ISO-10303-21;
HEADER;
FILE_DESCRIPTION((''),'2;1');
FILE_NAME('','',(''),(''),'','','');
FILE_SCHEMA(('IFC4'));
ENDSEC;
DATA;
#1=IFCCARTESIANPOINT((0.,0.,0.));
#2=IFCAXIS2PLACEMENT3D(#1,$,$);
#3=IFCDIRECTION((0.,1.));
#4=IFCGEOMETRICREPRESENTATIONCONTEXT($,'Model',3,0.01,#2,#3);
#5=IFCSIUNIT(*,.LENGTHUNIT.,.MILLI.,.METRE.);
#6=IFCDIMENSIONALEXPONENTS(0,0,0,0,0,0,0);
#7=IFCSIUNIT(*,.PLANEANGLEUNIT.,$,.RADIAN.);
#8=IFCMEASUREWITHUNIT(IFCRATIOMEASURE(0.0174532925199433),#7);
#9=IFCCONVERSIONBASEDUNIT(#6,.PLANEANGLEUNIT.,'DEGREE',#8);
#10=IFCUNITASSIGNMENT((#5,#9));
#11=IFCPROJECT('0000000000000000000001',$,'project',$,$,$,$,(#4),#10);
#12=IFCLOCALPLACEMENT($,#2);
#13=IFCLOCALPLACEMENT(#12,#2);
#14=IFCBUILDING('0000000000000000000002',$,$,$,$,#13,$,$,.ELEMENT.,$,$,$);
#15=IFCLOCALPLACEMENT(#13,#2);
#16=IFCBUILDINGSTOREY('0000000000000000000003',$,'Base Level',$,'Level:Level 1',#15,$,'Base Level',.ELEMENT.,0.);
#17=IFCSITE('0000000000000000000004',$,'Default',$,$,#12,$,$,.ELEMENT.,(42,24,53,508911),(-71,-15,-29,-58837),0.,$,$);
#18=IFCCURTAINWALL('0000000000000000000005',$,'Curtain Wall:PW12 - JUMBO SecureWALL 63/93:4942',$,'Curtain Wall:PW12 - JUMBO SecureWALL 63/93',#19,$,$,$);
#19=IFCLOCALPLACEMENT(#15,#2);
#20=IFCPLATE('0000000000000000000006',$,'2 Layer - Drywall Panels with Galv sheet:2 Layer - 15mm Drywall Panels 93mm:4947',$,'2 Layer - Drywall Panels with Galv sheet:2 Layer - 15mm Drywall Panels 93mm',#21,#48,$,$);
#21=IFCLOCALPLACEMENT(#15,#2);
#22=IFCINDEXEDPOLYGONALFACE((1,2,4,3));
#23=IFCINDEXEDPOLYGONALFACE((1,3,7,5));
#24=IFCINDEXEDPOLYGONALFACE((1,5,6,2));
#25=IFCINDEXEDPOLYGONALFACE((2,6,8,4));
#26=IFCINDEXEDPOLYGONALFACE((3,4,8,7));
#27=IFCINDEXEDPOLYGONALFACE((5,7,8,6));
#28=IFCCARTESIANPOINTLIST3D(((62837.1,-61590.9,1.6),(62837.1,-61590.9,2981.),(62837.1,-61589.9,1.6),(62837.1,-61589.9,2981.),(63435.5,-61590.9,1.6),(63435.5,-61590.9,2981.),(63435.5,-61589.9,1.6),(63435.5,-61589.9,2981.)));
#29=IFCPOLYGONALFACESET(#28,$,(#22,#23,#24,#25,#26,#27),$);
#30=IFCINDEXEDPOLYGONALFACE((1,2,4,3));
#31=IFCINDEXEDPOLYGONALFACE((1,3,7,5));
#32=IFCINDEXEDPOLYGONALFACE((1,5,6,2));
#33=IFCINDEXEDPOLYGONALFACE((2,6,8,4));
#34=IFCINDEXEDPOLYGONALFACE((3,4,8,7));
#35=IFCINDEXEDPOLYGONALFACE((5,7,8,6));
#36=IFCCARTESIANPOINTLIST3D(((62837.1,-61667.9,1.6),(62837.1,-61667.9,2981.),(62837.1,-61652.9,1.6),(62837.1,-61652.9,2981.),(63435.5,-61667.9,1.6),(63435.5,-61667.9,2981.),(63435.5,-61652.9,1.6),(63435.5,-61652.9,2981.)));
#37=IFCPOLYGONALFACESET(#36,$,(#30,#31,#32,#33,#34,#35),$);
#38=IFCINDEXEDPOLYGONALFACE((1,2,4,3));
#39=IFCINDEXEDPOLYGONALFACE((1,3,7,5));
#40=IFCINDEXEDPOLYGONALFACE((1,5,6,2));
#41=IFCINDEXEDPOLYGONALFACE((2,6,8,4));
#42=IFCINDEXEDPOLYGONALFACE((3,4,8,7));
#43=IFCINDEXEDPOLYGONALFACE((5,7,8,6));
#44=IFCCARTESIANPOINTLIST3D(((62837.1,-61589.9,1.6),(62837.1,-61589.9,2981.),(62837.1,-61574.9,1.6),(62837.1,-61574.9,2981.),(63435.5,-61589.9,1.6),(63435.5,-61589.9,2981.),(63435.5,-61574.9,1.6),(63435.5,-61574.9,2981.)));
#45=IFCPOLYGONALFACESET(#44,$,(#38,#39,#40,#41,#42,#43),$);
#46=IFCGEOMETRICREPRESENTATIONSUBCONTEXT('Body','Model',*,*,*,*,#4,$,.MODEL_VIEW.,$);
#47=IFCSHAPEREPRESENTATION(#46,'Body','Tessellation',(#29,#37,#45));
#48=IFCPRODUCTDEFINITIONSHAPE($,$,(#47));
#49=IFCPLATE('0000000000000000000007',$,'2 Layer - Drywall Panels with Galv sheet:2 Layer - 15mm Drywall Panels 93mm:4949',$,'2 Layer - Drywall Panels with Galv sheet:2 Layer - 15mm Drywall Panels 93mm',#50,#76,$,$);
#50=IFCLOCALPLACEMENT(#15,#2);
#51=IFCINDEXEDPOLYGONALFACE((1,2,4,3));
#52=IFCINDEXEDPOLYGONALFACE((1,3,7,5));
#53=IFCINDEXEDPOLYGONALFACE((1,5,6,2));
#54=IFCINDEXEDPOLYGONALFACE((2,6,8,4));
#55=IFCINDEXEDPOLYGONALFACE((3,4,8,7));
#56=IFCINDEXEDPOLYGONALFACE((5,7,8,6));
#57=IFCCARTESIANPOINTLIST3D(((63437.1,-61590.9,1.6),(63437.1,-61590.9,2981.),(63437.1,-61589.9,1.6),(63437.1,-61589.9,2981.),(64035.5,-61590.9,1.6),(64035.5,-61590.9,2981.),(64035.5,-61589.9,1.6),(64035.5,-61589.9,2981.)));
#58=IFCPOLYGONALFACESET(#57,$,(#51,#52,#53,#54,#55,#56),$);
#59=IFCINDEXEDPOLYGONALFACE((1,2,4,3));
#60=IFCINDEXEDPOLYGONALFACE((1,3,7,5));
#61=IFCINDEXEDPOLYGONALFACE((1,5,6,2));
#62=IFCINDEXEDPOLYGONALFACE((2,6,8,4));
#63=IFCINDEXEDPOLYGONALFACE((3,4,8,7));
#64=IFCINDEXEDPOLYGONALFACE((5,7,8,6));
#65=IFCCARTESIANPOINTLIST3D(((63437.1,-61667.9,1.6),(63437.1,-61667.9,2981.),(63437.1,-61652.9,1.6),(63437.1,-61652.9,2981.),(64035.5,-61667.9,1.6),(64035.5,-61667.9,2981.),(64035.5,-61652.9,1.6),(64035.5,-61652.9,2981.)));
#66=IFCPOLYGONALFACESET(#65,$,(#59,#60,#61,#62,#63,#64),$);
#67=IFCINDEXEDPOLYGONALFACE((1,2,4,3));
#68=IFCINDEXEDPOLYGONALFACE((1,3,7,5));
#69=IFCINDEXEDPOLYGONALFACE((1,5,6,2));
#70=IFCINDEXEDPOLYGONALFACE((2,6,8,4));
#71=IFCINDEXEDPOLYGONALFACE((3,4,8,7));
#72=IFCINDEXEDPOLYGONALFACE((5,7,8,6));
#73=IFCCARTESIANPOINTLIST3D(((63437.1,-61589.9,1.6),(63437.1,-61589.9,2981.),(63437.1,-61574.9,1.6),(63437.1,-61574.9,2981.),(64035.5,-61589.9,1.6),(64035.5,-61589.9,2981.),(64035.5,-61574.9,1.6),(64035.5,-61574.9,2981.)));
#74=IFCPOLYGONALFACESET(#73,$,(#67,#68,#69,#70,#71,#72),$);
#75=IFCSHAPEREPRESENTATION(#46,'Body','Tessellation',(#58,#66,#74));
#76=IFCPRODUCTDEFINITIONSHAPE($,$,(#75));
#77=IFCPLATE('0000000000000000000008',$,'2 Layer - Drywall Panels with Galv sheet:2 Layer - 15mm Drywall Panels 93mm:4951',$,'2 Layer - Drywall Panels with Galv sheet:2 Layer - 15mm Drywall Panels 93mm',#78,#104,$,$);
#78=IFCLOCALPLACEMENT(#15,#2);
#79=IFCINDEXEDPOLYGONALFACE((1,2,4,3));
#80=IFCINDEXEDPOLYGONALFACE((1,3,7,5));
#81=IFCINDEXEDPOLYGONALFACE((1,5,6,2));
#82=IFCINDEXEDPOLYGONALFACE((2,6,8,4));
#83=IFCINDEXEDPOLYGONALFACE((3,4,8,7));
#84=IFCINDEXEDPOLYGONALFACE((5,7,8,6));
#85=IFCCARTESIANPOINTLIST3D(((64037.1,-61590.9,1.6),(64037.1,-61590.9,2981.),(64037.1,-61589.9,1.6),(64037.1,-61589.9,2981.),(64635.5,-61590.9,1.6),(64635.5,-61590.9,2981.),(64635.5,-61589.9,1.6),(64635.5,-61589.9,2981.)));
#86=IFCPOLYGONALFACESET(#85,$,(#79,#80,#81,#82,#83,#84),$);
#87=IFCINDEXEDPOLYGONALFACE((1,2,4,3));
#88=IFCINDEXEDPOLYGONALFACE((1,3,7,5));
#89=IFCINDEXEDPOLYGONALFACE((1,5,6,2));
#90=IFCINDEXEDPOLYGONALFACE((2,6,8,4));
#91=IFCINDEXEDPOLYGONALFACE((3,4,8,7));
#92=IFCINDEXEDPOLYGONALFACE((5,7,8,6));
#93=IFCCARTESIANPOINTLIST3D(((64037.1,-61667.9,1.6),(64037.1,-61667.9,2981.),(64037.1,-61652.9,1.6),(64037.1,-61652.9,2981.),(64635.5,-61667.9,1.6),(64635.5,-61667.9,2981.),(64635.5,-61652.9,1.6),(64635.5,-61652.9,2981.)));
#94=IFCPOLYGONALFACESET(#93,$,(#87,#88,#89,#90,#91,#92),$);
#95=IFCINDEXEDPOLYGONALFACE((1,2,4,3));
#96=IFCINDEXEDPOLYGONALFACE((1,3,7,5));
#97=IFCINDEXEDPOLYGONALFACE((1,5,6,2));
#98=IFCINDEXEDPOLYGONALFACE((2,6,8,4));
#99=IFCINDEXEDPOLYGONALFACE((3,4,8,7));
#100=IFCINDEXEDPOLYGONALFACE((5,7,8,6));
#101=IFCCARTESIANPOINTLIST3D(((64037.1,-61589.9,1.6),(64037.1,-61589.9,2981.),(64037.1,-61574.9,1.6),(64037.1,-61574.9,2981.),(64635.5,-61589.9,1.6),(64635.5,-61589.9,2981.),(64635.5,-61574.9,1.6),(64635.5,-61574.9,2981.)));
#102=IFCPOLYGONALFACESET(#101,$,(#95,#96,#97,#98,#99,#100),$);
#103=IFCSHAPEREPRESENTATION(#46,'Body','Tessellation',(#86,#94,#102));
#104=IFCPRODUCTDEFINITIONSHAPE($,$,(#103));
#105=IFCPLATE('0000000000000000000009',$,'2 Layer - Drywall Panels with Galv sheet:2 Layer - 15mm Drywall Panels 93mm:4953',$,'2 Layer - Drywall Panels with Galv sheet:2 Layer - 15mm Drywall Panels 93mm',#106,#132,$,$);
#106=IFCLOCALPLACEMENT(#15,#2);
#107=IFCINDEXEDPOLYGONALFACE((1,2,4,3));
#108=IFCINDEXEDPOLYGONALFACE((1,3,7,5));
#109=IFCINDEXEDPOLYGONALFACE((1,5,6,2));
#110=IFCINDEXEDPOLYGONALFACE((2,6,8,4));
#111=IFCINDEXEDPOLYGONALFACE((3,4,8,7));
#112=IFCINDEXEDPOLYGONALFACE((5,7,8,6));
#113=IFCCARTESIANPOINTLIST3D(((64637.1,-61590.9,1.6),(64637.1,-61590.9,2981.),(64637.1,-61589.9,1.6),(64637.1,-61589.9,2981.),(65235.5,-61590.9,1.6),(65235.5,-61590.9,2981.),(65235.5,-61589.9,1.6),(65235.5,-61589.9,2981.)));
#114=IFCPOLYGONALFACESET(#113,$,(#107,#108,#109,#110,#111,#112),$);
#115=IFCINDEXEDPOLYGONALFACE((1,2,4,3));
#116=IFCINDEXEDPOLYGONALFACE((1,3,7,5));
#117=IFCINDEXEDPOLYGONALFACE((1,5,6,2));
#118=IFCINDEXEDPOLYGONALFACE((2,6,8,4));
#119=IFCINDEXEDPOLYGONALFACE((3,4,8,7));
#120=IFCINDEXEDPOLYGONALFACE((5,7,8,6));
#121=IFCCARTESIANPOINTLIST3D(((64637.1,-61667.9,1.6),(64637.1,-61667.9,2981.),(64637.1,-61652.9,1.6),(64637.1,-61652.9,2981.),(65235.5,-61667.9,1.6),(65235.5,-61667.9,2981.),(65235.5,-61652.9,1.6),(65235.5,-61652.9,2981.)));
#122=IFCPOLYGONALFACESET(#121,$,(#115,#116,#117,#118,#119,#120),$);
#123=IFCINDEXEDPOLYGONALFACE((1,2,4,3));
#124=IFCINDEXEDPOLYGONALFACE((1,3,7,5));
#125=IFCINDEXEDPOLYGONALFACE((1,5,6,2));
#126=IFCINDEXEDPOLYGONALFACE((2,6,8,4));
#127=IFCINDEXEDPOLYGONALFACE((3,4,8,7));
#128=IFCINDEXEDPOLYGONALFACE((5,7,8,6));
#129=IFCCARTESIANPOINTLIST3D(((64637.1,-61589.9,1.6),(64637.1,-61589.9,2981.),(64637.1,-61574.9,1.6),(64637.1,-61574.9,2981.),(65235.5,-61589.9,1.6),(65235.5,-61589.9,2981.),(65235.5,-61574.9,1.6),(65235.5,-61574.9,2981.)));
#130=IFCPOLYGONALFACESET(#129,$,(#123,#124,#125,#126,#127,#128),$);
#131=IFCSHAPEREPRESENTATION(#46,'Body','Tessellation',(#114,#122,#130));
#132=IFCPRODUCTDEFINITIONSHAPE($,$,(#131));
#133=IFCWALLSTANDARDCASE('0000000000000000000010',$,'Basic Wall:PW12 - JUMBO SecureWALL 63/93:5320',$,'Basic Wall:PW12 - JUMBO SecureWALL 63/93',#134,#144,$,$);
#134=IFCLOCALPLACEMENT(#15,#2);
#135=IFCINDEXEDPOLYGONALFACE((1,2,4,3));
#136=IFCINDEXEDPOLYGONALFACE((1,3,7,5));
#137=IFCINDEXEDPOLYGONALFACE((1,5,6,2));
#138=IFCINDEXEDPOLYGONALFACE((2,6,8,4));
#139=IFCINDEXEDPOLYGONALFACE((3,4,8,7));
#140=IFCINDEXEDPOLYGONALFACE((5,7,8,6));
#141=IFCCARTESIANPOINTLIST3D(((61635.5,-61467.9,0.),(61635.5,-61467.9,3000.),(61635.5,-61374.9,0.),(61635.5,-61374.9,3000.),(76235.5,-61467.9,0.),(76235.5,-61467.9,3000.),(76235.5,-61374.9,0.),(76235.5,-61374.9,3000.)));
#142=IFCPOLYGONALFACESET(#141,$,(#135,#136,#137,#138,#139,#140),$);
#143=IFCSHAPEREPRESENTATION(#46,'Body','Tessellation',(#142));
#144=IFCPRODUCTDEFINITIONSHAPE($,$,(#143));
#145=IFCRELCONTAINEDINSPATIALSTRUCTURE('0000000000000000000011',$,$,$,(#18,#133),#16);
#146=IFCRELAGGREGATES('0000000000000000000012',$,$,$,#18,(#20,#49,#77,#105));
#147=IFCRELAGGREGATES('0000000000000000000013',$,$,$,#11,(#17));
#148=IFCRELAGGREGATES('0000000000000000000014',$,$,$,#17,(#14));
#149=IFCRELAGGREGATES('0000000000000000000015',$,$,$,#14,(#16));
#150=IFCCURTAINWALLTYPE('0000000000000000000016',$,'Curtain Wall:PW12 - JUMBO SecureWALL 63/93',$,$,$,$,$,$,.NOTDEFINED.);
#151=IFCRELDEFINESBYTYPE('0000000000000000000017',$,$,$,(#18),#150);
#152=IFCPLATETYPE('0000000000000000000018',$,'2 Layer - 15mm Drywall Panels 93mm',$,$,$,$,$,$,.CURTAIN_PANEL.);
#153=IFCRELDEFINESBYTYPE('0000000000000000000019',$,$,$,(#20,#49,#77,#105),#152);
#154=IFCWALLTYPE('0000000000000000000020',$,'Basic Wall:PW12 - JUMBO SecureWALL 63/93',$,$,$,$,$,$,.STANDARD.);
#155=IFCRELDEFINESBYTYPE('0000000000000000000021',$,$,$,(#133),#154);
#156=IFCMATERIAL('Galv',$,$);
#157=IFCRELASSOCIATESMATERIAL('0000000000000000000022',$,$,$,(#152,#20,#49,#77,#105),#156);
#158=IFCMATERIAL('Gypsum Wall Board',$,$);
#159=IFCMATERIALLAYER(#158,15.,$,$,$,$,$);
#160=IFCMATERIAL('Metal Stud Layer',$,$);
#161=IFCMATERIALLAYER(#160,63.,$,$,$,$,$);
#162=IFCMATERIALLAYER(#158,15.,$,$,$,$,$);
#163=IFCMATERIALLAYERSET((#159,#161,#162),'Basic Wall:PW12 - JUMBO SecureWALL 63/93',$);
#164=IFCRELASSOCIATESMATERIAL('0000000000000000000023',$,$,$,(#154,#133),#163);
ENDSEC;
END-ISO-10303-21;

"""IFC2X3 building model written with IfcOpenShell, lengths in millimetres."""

from ifc_helpers import new_model, entity, si_unit, converted_unit, direction, frame, frame_2d, origin, origin_2d_with_axis, place, context, subcontext, project, spatial, rectangle, extrude, source, transform, mapped, material, layer, layer_set, layer_usage, type_object, type_shapes, element, aggregate, save


model = new_model("IFC2X3")

# Units and contexts
model_context = context("Model", 3, precision=0.01, world=origin(), true_north=direction((0.0, 1.0)))
body_context = subcontext(model_context, "Body", "Model", "MODEL_VIEW")
ifc_project = project(units=[si_unit("LENGTHUNIT", "METRE", prefix="MILLI"), converted_unit("PLANEANGLEUNIT", "DEGREE", entity("IfcRatioMeasure", 0.0174532925199433), si_unit("PLANEANGLEUNIT", "RADIAN"), dimensions=[0, 0, 0, 0, 0, 0, 0])], contexts=[model_context])

# Site, building, storey
site_placement = place(None, origin())
site = spatial("IfcSite", under=ifc_project, at=site_placement, Name="Default", CompositionType="ELEMENT", RefLatitude=(42, 24, 53, 508911), RefLongitude=(-71, -15, -29, -58837), RefElevation=0.0)
building_placement = place(site_placement, origin())
building = spatial("IfcBuilding", under=site, at=building_placement, CompositionType="ELEMENT")
storey_placement = place(building_placement, origin())
storey = spatial("IfcBuildingStorey", under=building, at=storey_placement, Name="Base Level", ObjectType="Level:Level 1", LongName="Base Level", CompositionType="ELEMENT", Elevation=0.0)

# Curtain wall, plates
curtain_wall_type = type_object("IfcCurtainWallType", Name="Curtain Wall:PW12 - JUMBO SecureWALL 63/93", PredefinedType="NOTDEFINED")
curtain_wall_placement = place(building_placement, origin())
curtain_wall = element("IfcCurtainWall", 1, at=curtain_wall_placement, inside=storey, type_object=curtain_wall_type, Name="Curtain Wall:PW12 - JUMBO SecureWALL 63/93:4942", ObjectType="Curtain Wall:PW12 - JUMBO SecureWALL 63/93")
ifc_material_1 = material(Name="Galv")
plate_type = type_object("IfcPlateType", Name="2 Layer - 15mm Drywall Panels 93mm", PredefinedType="CURTAIN_PANEL", material=ifc_material_1)
shared_shape_1 = source(origin(), body_context, "Body", "SweptSolid", [
    extrude(rectangle(XDim=598.4, YDim=1.0, at=origin_2d_with_axis()), frame((0.0, 31.0, 0.0), z_axis=(0.0, 0.0, 1.0), x_axis=(-1.0, 0.0, 0.0)), (0.0, 0.0, 1.0), 2979.4),
    extrude(rectangle(XDim=598.4, YDim=15.0, at=frame_2d((0.0, 0.0), x_axis=(1.0, 0.0))), frame((0.0, -39.0, 0.0), z_axis=(0.0, 0.0, 1.0), x_axis=(-1.0, 0.0, 0.0)), (0.0, 0.0, 1.0), 2979.4),
    extrude(rectangle(XDim=15.0, YDim=598.4, at=frame_2d((0.0, 0.0), x_axis=(1.0, 0.0))), frame((0.0, 39.0, 0.0), z_axis=(0.0, 0.0, 1.0), x_axis=(0.0, 1.0, 0.0)), (0.0, 0.0, 1.0), 2979.4),
])
type_shapes(plate_type, [shared_shape_1])
plate_1_placement = place(curtain_wall_placement, frame((63136.3, -61621.4, 1.6)))
plate_1 = element("IfcPlate", 2, at=plate_1_placement, type_object=plate_type, material=ifc_material_1, Name="2 Layer - Drywall Panels with Galv sheet:2 Layer - 15mm Drywall Panels 93mm:4947", ObjectType="2 Layer - Drywall Panels with Galv sheet:2 Layer - 15mm Drywall Panels 93mm", context=body_context, shape_type="MappedRepresentation", body=[
    mapped(shared_shape_1, transform((0.0, 0.0, 0.0), scale=1.0)),
])
plate_2_placement = place(curtain_wall_placement, frame((63736.3, -61621.4, 1.6)))
plate_2 = element("IfcPlate", 3, at=plate_2_placement, type_object=plate_type, material=ifc_material_1, Name="2 Layer - Drywall Panels with Galv sheet:2 Layer - 15mm Drywall Panels 93mm:4949", ObjectType="2 Layer - Drywall Panels with Galv sheet:2 Layer - 15mm Drywall Panels 93mm", context=body_context, shape_type="MappedRepresentation", body=[
    mapped(shared_shape_1, transform((0.0, 0.0, 0.0), scale=1.0)),
])
plate_3_placement = place(curtain_wall_placement, frame((64336.3, -61621.4, 1.6)))
plate_3 = element("IfcPlate", 4, at=plate_3_placement, type_object=plate_type, material=ifc_material_1, Name="2 Layer - Drywall Panels with Galv sheet:2 Layer - 15mm Drywall Panels 93mm:4951", ObjectType="2 Layer - Drywall Panels with Galv sheet:2 Layer - 15mm Drywall Panels 93mm", context=body_context, shape_type="MappedRepresentation", body=[
    mapped(shared_shape_1, transform((0.0, 0.0, 0.0), scale=1.0)),
])
plate_4_placement = place(curtain_wall_placement, frame((64936.3, -61621.4, 1.6)))
plate_4 = element("IfcPlate", 5, at=plate_4_placement, type_object=plate_type, material=ifc_material_1, Name="2 Layer - Drywall Panels with Galv sheet:2 Layer - 15mm Drywall Panels 93mm:4953", ObjectType="2 Layer - Drywall Panels with Galv sheet:2 Layer - 15mm Drywall Panels 93mm", context=body_context, shape_type="MappedRepresentation", body=[
    mapped(shared_shape_1, transform((0.0, 0.0, 0.0), scale=1.0)),
])
aggregate(curtain_wall, [plate_1, plate_2, plate_3, plate_4])

# Wall
ifc_material_2 = material(Name="Gypsum Wall Board")
ifc_layer_1 = layer(ifc_material_2, 15.0)
ifc_material_3 = material(Name="Metal Stud Layer")
ifc_layer_2 = layer(ifc_material_3, 63.0)
ifc_layer_3 = layer(ifc_material_2, 15.0)
ifc_layer_set = layer_set([ifc_layer_1, ifc_layer_2, ifc_layer_3], Name="Basic Wall:PW12 - JUMBO SecureWALL 63/93")
ifc_layer_usage = layer_usage(ifc_layer_set, "AXIS2", "NEGATIVE", 46.5)
wall_type = type_object("IfcWallType", Name="Basic Wall:PW12 - JUMBO SecureWALL 63/93", PredefinedType="STANDARD", material=ifc_layer_set)
wall_placement = place(building_placement, frame((61635.5, -61421.4, 0.0)))
element("IfcWallStandardCase", 6, at=wall_placement, inside=storey, type_object=wall_type, material=ifc_layer_usage, Name="Basic Wall:PW12 - JUMBO SecureWALL 63/93:5320", ObjectType="Basic Wall:PW12 - JUMBO SecureWALL 63/93", context=body_context, shape_type="SweptSolid", body=[
    extrude(rectangle(XDim=14600.0, YDim=93.0, at=frame_2d((7300.0, 0.0), x_axis=(-1.0, 0.0))), origin(), (0.0, 0.0, 1.0), 3000.0),
])

save(model, "model.ifc")
